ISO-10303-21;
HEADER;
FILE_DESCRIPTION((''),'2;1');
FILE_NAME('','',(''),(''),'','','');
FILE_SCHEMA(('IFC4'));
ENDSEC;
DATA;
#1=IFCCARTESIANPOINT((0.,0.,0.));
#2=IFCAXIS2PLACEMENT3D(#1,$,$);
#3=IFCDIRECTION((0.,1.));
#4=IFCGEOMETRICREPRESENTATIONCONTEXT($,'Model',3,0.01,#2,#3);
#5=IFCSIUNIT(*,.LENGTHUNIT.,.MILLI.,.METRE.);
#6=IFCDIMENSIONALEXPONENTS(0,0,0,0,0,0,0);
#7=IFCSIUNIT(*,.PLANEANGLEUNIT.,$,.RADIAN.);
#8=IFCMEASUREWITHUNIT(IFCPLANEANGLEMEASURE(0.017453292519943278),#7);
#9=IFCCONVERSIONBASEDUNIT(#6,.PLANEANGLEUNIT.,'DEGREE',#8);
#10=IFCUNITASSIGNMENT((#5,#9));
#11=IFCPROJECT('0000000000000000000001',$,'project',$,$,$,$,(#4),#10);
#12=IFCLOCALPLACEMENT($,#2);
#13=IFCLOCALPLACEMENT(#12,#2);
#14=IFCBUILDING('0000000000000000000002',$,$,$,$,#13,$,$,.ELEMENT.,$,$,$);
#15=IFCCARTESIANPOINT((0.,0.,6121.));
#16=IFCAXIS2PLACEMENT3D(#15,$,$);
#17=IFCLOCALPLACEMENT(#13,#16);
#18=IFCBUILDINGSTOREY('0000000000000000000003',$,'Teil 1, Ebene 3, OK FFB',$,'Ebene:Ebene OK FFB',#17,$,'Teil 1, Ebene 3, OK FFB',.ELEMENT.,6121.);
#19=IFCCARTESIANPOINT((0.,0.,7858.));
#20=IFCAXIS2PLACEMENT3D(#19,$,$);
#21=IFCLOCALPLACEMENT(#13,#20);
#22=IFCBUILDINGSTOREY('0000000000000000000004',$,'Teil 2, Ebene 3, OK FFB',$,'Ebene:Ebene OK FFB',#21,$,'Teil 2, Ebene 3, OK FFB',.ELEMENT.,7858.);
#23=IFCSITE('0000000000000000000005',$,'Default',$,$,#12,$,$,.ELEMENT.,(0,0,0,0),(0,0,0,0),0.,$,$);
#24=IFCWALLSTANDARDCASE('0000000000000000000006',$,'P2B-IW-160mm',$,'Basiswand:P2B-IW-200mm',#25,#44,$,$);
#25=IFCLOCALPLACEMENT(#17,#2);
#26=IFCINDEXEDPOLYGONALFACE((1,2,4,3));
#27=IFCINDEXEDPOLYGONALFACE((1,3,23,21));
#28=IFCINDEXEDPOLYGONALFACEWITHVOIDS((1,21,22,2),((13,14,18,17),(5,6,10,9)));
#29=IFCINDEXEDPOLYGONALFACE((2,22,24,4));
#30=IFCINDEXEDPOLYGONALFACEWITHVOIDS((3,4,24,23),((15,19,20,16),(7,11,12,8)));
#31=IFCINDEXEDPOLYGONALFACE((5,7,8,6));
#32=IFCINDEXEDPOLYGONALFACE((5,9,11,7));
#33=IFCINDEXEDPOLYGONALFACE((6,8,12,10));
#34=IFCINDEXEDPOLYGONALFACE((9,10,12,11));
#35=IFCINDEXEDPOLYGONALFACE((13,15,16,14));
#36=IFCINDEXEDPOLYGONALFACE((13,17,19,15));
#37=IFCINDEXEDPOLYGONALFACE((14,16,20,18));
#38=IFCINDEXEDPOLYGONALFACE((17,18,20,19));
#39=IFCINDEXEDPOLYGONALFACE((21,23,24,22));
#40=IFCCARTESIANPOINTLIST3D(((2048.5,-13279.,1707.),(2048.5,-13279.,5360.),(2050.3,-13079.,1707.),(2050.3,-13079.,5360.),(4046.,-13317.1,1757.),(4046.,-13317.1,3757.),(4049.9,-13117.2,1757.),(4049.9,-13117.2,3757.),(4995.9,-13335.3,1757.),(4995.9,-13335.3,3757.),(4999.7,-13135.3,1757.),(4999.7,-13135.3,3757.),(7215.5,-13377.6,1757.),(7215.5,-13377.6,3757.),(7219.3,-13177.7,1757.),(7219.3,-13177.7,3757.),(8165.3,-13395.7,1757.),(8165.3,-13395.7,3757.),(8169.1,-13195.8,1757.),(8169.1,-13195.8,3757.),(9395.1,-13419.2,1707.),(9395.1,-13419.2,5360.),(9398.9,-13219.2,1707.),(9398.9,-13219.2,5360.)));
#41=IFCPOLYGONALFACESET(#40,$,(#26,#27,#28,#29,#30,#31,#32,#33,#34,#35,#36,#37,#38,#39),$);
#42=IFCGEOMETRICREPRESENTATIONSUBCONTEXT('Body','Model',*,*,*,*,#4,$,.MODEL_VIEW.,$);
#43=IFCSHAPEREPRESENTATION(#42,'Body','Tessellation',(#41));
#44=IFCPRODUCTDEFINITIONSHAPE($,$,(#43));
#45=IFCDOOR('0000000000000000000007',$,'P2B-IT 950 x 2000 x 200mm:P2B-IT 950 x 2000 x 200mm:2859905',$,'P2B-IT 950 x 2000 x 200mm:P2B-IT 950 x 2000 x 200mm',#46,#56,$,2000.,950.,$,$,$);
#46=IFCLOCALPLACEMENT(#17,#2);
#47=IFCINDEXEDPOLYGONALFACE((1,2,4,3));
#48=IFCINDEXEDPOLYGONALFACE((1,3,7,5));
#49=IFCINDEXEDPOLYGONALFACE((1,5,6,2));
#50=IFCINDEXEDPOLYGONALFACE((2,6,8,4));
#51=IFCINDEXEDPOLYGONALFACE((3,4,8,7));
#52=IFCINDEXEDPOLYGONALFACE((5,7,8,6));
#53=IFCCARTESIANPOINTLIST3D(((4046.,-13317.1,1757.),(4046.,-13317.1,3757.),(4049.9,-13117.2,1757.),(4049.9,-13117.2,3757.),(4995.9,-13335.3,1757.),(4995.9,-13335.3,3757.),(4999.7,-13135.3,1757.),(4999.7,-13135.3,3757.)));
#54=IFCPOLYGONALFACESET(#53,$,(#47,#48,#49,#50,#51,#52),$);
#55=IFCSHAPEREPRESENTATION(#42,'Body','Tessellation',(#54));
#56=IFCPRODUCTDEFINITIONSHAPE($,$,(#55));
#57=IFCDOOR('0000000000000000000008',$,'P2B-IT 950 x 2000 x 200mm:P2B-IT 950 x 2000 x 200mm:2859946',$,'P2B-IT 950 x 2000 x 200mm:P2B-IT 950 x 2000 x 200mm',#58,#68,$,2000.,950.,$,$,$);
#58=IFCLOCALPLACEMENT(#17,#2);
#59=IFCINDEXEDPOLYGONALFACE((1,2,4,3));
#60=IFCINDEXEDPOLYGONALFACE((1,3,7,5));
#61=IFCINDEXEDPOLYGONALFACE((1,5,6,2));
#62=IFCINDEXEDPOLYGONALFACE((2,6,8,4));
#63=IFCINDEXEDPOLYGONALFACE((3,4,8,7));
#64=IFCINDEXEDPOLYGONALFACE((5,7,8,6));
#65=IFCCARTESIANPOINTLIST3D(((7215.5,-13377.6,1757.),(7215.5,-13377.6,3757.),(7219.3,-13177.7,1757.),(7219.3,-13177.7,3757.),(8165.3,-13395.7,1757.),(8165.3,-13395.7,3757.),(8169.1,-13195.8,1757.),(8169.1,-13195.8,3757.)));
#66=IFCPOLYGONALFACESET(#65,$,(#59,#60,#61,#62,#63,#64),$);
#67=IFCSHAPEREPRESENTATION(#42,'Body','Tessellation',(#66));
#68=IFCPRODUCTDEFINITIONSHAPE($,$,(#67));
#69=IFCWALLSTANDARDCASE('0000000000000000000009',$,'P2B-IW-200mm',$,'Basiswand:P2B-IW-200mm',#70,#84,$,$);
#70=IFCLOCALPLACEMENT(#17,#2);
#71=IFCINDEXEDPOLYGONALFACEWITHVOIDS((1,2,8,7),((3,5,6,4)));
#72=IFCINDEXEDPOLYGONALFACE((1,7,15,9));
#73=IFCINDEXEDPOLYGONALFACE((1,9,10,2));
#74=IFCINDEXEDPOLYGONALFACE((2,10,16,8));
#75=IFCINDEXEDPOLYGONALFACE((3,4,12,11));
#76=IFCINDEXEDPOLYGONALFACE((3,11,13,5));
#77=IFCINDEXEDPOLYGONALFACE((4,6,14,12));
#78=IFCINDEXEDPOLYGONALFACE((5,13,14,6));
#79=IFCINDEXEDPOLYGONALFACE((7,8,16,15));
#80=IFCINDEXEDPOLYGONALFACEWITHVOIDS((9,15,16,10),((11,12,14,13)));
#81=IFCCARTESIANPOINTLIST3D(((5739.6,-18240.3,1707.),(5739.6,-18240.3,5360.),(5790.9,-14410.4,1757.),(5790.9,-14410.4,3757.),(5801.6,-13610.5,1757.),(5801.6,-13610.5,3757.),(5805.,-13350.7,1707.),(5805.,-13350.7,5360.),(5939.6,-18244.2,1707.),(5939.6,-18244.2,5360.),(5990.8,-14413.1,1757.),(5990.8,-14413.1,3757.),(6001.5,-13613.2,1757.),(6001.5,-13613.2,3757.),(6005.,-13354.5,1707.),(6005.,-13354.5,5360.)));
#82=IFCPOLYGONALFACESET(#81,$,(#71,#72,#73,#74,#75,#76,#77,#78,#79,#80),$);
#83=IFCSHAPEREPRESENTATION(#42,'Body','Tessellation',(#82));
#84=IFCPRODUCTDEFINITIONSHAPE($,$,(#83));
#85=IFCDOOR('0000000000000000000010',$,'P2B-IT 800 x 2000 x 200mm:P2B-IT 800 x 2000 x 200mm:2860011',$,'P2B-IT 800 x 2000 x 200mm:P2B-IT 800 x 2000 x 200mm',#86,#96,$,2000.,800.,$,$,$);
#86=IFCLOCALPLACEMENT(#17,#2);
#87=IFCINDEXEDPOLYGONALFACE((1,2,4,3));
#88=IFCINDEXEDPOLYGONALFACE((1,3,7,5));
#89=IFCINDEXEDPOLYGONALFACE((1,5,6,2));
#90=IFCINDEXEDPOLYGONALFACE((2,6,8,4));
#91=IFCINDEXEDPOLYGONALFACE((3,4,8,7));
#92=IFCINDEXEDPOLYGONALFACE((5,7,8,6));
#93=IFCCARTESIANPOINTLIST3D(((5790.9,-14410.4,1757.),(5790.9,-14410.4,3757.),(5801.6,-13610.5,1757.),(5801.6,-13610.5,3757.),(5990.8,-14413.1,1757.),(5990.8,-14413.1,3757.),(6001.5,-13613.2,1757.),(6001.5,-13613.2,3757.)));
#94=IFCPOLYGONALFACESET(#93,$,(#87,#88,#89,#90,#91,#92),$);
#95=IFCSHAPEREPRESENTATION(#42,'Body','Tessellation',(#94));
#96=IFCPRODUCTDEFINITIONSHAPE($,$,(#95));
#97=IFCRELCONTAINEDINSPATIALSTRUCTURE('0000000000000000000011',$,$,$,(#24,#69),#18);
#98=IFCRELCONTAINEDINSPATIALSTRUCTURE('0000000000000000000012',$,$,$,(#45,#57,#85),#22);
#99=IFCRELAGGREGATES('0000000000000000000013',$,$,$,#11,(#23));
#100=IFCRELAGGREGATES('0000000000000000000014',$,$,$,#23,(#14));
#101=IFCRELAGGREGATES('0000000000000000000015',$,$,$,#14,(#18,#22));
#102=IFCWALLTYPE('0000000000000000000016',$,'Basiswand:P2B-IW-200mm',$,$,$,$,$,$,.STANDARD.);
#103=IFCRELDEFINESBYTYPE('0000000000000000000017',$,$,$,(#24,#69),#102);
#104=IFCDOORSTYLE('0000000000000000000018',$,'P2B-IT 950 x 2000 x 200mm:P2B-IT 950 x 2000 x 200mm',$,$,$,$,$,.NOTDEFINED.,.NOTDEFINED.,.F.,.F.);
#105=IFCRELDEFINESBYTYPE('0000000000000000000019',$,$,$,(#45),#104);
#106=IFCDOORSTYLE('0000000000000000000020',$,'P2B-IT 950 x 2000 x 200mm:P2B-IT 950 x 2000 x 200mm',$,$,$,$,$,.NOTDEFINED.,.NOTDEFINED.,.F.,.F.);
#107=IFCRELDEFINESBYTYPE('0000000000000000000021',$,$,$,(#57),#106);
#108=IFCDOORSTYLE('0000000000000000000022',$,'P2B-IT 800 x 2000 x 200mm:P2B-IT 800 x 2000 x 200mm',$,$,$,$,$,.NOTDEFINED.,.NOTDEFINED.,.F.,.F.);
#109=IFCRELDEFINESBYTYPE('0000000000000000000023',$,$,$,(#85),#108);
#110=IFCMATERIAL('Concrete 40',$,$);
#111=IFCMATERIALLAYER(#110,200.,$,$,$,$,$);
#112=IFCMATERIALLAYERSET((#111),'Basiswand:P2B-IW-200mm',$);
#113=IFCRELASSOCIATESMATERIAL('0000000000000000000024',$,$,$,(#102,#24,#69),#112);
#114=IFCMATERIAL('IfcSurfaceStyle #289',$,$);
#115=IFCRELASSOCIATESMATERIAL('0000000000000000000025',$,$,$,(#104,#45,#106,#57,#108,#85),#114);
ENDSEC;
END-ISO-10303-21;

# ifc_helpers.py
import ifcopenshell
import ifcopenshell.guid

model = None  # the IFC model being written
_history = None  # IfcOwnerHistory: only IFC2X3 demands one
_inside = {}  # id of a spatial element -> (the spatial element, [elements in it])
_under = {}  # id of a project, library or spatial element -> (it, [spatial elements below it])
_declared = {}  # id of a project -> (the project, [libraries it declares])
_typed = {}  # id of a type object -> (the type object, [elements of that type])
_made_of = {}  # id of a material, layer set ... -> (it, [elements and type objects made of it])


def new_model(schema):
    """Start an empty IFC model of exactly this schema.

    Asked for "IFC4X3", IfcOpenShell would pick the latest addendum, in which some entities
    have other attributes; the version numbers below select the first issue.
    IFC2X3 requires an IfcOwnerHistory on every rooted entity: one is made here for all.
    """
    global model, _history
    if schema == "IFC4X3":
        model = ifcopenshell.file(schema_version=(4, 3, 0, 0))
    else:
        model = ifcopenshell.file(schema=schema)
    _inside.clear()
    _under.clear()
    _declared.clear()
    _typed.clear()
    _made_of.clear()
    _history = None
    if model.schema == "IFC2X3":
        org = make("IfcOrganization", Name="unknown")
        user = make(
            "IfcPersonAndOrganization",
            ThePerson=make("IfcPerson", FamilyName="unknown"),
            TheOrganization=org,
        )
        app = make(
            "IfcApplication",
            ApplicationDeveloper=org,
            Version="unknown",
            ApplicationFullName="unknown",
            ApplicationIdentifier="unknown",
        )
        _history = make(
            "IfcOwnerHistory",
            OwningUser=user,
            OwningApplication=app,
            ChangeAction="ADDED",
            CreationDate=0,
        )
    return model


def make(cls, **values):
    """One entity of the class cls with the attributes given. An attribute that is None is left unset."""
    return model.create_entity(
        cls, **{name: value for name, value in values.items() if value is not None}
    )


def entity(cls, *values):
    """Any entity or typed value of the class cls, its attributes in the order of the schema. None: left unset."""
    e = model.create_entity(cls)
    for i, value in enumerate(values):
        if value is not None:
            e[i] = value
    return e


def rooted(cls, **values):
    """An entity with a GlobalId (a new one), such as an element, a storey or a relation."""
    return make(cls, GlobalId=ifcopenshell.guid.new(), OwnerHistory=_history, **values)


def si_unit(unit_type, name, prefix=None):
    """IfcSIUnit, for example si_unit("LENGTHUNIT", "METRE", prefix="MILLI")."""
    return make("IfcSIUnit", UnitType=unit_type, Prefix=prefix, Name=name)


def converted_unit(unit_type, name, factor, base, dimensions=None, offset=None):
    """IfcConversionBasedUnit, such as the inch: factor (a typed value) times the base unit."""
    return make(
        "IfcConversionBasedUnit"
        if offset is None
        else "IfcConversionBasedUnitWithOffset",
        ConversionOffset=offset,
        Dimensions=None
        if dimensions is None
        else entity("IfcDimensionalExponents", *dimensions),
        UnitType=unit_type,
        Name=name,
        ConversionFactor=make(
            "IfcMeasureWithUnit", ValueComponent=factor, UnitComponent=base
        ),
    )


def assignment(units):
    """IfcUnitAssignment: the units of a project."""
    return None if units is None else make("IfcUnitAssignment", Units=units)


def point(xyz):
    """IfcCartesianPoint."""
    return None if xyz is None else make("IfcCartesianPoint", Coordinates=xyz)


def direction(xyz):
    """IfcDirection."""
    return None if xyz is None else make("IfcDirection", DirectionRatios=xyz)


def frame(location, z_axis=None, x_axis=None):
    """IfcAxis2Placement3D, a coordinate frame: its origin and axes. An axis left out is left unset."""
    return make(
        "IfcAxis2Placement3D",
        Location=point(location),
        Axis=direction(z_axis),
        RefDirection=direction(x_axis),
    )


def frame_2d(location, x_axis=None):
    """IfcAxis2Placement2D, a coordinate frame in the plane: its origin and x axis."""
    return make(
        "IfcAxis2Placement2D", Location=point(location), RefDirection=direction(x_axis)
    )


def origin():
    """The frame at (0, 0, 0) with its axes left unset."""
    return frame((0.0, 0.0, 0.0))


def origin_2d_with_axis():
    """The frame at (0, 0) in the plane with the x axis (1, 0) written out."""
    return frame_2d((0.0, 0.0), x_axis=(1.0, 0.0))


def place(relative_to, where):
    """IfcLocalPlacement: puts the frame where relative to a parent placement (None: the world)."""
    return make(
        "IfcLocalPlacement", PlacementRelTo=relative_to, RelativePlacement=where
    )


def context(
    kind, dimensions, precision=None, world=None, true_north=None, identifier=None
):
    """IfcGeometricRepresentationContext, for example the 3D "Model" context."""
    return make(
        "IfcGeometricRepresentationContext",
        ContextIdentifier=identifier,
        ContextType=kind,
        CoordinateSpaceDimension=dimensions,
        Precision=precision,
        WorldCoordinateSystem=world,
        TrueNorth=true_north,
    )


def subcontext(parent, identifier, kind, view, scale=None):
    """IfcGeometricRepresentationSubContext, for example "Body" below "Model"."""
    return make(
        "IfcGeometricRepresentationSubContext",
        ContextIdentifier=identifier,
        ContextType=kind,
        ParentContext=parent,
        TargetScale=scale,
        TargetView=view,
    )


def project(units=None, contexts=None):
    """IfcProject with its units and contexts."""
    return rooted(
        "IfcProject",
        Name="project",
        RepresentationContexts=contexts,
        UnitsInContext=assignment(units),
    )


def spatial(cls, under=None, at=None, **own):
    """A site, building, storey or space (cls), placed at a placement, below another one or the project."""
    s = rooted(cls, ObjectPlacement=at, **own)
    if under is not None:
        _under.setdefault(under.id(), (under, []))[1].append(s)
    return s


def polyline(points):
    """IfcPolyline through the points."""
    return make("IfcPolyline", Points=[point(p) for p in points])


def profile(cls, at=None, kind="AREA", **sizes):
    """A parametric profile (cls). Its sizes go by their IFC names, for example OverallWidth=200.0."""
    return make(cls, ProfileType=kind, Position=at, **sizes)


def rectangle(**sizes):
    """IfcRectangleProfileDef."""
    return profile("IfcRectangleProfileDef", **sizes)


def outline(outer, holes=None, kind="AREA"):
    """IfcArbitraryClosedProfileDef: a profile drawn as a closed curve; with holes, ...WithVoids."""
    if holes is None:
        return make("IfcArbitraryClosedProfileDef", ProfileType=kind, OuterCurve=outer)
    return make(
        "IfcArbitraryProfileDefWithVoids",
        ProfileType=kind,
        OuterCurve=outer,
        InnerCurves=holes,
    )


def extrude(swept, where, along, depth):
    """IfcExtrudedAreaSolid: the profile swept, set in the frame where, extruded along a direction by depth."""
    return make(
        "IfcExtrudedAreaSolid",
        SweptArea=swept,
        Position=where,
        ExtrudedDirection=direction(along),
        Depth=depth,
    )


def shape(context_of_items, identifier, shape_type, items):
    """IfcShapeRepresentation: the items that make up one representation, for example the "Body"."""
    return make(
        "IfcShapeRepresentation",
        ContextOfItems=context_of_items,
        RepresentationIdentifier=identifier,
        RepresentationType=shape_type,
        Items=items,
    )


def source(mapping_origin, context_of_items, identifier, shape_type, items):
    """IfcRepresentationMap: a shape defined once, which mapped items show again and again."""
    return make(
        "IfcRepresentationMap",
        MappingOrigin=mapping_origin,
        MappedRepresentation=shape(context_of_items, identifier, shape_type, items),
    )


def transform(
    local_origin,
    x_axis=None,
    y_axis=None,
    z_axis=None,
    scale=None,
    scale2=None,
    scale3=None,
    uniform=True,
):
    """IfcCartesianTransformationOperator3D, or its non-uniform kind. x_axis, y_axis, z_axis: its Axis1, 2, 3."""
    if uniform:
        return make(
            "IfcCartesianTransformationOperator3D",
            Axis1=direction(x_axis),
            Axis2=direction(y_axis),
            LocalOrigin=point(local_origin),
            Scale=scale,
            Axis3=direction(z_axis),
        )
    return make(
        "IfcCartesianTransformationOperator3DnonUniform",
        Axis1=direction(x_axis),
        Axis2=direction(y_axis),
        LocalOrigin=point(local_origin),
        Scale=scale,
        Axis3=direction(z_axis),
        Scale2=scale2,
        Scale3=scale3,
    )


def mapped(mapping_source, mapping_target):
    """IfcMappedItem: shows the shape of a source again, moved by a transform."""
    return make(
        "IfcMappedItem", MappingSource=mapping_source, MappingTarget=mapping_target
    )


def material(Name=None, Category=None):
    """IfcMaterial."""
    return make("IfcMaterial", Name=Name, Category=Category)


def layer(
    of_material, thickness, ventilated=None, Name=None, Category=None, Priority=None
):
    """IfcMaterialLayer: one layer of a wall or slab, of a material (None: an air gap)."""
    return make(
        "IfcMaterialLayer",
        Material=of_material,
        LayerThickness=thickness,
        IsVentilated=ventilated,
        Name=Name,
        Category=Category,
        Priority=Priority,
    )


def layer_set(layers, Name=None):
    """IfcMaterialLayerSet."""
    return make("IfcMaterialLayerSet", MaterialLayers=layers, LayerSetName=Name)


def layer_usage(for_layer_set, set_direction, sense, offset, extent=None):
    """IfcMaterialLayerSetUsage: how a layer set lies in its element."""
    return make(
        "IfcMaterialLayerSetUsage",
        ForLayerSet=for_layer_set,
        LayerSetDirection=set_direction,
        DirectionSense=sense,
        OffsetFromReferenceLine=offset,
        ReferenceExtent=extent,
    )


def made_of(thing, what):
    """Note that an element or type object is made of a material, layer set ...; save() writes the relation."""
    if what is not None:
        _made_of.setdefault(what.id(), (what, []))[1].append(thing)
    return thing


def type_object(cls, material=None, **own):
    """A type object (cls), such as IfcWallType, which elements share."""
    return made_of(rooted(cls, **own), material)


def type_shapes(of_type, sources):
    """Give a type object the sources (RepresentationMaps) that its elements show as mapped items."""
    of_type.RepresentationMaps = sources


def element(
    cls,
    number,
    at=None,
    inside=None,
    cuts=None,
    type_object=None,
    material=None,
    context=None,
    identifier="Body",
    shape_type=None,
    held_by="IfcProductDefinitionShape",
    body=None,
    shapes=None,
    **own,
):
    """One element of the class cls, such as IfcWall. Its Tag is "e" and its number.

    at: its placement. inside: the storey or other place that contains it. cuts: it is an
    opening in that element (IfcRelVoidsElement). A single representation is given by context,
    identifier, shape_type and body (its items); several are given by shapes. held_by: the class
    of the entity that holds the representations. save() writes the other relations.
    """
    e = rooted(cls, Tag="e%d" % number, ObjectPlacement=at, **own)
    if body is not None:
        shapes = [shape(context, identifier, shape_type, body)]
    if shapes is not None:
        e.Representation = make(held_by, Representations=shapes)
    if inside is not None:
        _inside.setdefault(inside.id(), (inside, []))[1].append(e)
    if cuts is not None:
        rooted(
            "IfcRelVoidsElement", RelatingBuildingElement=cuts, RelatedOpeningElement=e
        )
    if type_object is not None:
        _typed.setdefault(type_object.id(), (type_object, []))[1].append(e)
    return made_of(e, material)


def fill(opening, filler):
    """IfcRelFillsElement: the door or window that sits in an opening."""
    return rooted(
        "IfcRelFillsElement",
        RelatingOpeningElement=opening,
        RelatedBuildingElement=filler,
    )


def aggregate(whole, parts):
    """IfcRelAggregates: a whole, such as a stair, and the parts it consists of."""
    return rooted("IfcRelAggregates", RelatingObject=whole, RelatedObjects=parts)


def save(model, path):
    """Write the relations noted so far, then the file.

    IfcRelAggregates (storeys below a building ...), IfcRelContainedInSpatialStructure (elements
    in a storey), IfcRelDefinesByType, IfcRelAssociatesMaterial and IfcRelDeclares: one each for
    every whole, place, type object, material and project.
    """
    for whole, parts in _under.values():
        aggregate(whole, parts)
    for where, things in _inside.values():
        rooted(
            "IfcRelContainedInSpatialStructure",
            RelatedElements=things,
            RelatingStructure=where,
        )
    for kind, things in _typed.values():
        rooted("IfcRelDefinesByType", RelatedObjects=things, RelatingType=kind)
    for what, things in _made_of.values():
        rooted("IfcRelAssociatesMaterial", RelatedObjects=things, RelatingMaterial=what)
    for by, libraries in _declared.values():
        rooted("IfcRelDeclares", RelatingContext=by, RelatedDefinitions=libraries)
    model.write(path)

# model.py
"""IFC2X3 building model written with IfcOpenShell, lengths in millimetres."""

from ifc_helpers import new_model, entity, si_unit, converted_unit, direction, frame, frame_2d, origin, origin_2d_with_axis, place, context, subcontext, project, spatial, polyline, rectangle, outline, extrude, source, transform, mapped, material, layer, layer_set, layer_usage, type_object, type_shapes, element, fill, save


model = new_model("IFC2X3")

# Units and contexts
model_context = context("Model", 3, precision=0.01, world=origin(), true_north=direction((0.0, 1.0)))
body_context = subcontext(model_context, "Body", "Model", "MODEL_VIEW")
ifc_project = project(units=[si_unit("LENGTHUNIT", "METRE", prefix="MILLI"), converted_unit("PLANEANGLEUNIT", "DEGREE", entity("IfcPlaneAngleMeasure", 0.017453292519943278), si_unit("PLANEANGLEUNIT", "RADIAN"), dimensions=[0, 0, 0, 0, 0, 0, 0])], contexts=[model_context])

# Site, building, storey
site_placement = place(None, origin())
site = spatial("IfcSite", under=ifc_project, at=site_placement, Name="Default", CompositionType="ELEMENT", RefLatitude=(0, 0, 0, 0), RefLongitude=(0, 0, 0, 0), RefElevation=0.0)
building_placement = place(site_placement, origin())
building = spatial("IfcBuilding", under=site, at=building_placement, CompositionType="ELEMENT")
storey_1_placement = place(building_placement, frame((0.0, 0.0, 6121.0)))
storey_1 = spatial("IfcBuildingStorey", under=building, at=storey_1_placement, Name="Teil 1, Ebene 3, OK FFB", ObjectType="Ebene:Ebene OK FFB", LongName="Teil 1, Ebene 3, OK FFB", CompositionType="ELEMENT", Elevation=6121.0)

# Wall, openings
ifc_material_1 = material(Name="Concrete 40")
ifc_layer = layer(ifc_material_1, 200.0)
ifc_layer_set = layer_set([ifc_layer], Name="Basiswand:P2B-IW-200mm")
ifc_layer_usage_1 = layer_usage(ifc_layer_set, "AXIS2", "NEGATIVE", 100.0)
wall_type = type_object("IfcWallType", Name="Basiswand:P2B-IW-200mm", PredefinedType="STANDARD", material=ifc_layer_set)
wall_1_placement = place(storey_1_placement, frame((9397.0, -13319.2, 1707.0), z_axis=(0.0, 0.0, 1.0), x_axis=(-0.999818, 0.019077, 0.0)))
wall_1 = element("IfcWallStandardCase", 1, at=wall_1_placement, inside=storey_1, type_object=wall_type, material=ifc_layer_usage_1, Name="P2B-IW-160mm", ObjectType="Basiswand:P2B-IW-200mm", context=body_context, shape_type="SweptSolid", body=[
    extrude(outline(polyline([(7349.9, -100.0), (7347.9, 100.0), (3590.7, 100.0), (3390.7, 100.0), (0.0, 100.0), (0.0, -100.0), (7149.9, -100.0), (7349.9, -100.0)])), origin(), (0.0, 0.0, 1.0), 3653.0),
])
opening_1_placement = place(wall_1_placement, frame((9649.4, -13137.5, 30.0), z_axis=(0.0, 0.0, 1.0), x_axis=(-0.999818, -0.019077, 0.0)))
opening_1 = element("IfcOpeningElement", 2, at=opening_1_placement, cuts=wall_1, ObjectType="Opening", context=body_context, shape_type="SweptSolid", body=[
    extrude(rectangle(XDim=2000.0, YDim=950.0, at=frame_2d((0.0, 0.0), x_axis=(1.0, 0.0))), frame((4524.8, -13126.2, 1020.0), z_axis=(-0.019077, -0.999818, 0.0), x_axis=(0.0, 0.0, -1.0)), (0.0, 0.0, 1.0), 200.0),
])
opening_2_placement = place(wall_1_placement, frame((9649.4, -13137.5, 30.0), z_axis=(0.0, 0.0, 1.0), x_axis=(-0.999818, -0.019077, 0.0)))
opening_2 = element("IfcOpeningElement", 3, at=opening_2_placement, cuts=wall_1, ObjectType="Opening", context=body_context, shape_type="SweptSolid", body=[
    extrude(rectangle(XDim=2000.0, YDim=950.0, at=origin_2d_with_axis()), frame((7694.2, -13186.7, 1020.0), z_axis=(-0.019077, -0.999818, 0.0), x_axis=(0.0, 0.0, -1.0)), (0.0, 0.0, 1.0), 200.0),
])

# Shared definitions
storey_2_placement = place(building_placement, frame((0.0, 0.0, 7858.0)))
storey_2 = spatial("IfcBuildingStorey", under=building, at=storey_2_placement, Name="Teil 2, Ebene 3, OK FFB", ObjectType="Ebene:Ebene OK FFB", LongName="Teil 2, Ebene 3, OK FFB", CompositionType="ELEMENT", Elevation=7858.0)

# Doors
ifc_material_2 = material(Name="IfcSurfaceStyle #289")
door_style_1 = type_object("IfcDoorStyle", Name="P2B-IT 950 x 2000 x 200mm:P2B-IT 950 x 2000 x 200mm", ConstructionType="NOTDEFINED", OperationType="NOTDEFINED", ParameterTakesPrecedence=False, Sizeable=False, material=ifc_material_2)
shared_shape_1 = source(origin(), body_context, "Body", "SweptSolid", [
    extrude(rectangle(XDim=200.0, YDim=950.0, at=frame_2d((0.0, 0.0), x_axis=(1.0, 0.0))), frame((475.0, 100.0, 0.0), z_axis=(0.0, 0.0, 1.0), x_axis=(0.0, 1.0, 0.0)), (0.0, 0.0, 1.0), 2000.0),
])
type_shapes(door_style_1, [shared_shape_1])
door_1_placement = place(opening_1_placement, frame((4046.0, -13317.1, 20.0), z_axis=(0.0, 0.0, 1.0), x_axis=(0.999818, -0.019077, 0.0)))
door_1 = element("IfcDoor", 4, at=door_1_placement, inside=storey_2, type_object=door_style_1, material=ifc_material_2, Name="P2B-IT 950 x 2000 x 200mm:P2B-IT 950 x 2000 x 200mm:2859905", ObjectType="P2B-IT 950 x 2000 x 200mm:P2B-IT 950 x 2000 x 200mm", OverallHeight=2000.0, OverallWidth=950.0, context=body_context, shape_type="MappedRepresentation", body=[
    mapped(shared_shape_1, transform((0.0, 0.0, 0.0), scale=1.0)),
])
fill(opening_1, door_1)
door_style_2 = type_object("IfcDoorStyle", Name="P2B-IT 950 x 2000 x 200mm:P2B-IT 950 x 2000 x 200mm", ConstructionType="NOTDEFINED", OperationType="NOTDEFINED", ParameterTakesPrecedence=False, Sizeable=False, material=ifc_material_2)
shared_shape_2 = source(origin(), body_context, "Body", "SweptSolid", [
    extrude(rectangle(XDim=200.0, YDim=950.0, at=frame_2d((0.0, 0.0), x_axis=(1.0, 0.0))), frame((475.0, -100.0, 0.0), z_axis=(0.0, 0.0, 1.0), x_axis=(0.0, 1.0, 0.0)), (0.0, 0.0, 1.0), 2000.0),
])
type_shapes(door_style_2, [shared_shape_2])
door_2_placement = place(opening_2_placement, frame((8165.3, -13395.7, 20.0), z_axis=(0.0, 0.0, 1.0), x_axis=(-0.999818, 0.019077, 0.0)))
door_2 = element("IfcDoor", 5, at=door_2_placement, inside=storey_2, type_object=door_style_2, material=ifc_material_2, Name="P2B-IT 950 x 2000 x 200mm:P2B-IT 950 x 2000 x 200mm:2859946", ObjectType="P2B-IT 950 x 2000 x 200mm:P2B-IT 950 x 2000 x 200mm", OverallHeight=2000.0, OverallWidth=950.0, context=body_context, shape_type="MappedRepresentation", body=[
    mapped(shared_shape_2, transform((0.0, 0.0, 0.0), scale=1.0)),
])
fill(opening_2, door_2)

# Wall, opening, door
ifc_layer_usage_2 = layer_usage(ifc_layer_set, "AXIS2", "NEGATIVE", 100.0)
wall_2_placement = place(storey_1_placement, frame((5839.6, -18242.8, 1707.0), z_axis=(0.0, 0.0, 1.0), x_axis=(0.013383, 0.99991, 0.0)))
wall_2 = element("IfcWallStandardCase", 6, at=wall_2_placement, inside=storey_1, type_object=wall_type, material=ifc_layer_usage_2, Name="P2B-IW-200mm", ObjectType="Basiswand:P2B-IW-200mm", context=body_context, shape_type="SweptSolid", body=[
    extrude(outline(polyline([(4890.1, -100.0), (4891.2, 100.0), (1.1, 100.0), (0.0, -100.0), (4890.1, -100.0)])), origin(), (0.0, 0.0, 1.0), 3653.0),
])
opening_3_placement = place(wall_2_placement, frame((18163.0, 6083.2, 30.0), z_axis=(0.0, 0.0, 1.0), x_axis=(0.013383, -0.99991, 0.0)))
opening_3 = element("IfcOpeningElement", 7, at=opening_3_placement, cuts=wall_2, ObjectType="Opening", context=body_context, shape_type="SweptSolid", body=[
    extrude(rectangle(XDim=2000.0, YDim=800.0, at=frame_2d((0.0, 0.0), x_axis=(1.0, 0.0))), frame((5996.2, -14013.1, 1020.0), z_axis=(-0.99991, 0.013383, 0.0), x_axis=(0.0, 0.0, -1.0)), (0.0, 0.0, 1.0), 200.0),
])
door_style_3 = type_object("IfcDoorStyle", Name="P2B-IT 800 x 2000 x 200mm:P2B-IT 800 x 2000 x 200mm", ConstructionType="NOTDEFINED", OperationType="NOTDEFINED", ParameterTakesPrecedence=False, Sizeable=False, material=ifc_material_2)
shared_shape_3 = source(origin(), body_context, "Body", "SweptSolid", [
    extrude(rectangle(XDim=200.0, YDim=800.0, at=origin_2d_with_axis()), frame((400.0, 100.0, 0.0), z_axis=(0.0, 0.0, 1.0), x_axis=(0.0, 1.0, 0.0)), (0.0, 0.0, 1.0), 2000.0),
])
type_shapes(door_style_3, [shared_shape_3])
door_3_placement = place(opening_3_placement, frame((5801.6, -13610.5, 20.0), z_axis=(0.0, 0.0, 1.0), x_axis=(-0.013383, -0.99991, 0.0)))
door_3 = element("IfcDoor", 8, at=door_3_placement, inside=storey_2, type_object=door_style_3, material=ifc_material_2, Name="P2B-IT 800 x 2000 x 200mm:P2B-IT 800 x 2000 x 200mm:2860011", ObjectType="P2B-IT 800 x 2000 x 200mm:P2B-IT 800 x 2000 x 200mm", OverallHeight=2000.0, OverallWidth=800.0, context=body_context, shape_type="MappedRepresentation", body=[
    mapped(shared_shape_3, transform((0.0, 0.0, 0.0), scale=1.0)),
])
fill(opening_3, door_3)

save(model, "model.ifc")
